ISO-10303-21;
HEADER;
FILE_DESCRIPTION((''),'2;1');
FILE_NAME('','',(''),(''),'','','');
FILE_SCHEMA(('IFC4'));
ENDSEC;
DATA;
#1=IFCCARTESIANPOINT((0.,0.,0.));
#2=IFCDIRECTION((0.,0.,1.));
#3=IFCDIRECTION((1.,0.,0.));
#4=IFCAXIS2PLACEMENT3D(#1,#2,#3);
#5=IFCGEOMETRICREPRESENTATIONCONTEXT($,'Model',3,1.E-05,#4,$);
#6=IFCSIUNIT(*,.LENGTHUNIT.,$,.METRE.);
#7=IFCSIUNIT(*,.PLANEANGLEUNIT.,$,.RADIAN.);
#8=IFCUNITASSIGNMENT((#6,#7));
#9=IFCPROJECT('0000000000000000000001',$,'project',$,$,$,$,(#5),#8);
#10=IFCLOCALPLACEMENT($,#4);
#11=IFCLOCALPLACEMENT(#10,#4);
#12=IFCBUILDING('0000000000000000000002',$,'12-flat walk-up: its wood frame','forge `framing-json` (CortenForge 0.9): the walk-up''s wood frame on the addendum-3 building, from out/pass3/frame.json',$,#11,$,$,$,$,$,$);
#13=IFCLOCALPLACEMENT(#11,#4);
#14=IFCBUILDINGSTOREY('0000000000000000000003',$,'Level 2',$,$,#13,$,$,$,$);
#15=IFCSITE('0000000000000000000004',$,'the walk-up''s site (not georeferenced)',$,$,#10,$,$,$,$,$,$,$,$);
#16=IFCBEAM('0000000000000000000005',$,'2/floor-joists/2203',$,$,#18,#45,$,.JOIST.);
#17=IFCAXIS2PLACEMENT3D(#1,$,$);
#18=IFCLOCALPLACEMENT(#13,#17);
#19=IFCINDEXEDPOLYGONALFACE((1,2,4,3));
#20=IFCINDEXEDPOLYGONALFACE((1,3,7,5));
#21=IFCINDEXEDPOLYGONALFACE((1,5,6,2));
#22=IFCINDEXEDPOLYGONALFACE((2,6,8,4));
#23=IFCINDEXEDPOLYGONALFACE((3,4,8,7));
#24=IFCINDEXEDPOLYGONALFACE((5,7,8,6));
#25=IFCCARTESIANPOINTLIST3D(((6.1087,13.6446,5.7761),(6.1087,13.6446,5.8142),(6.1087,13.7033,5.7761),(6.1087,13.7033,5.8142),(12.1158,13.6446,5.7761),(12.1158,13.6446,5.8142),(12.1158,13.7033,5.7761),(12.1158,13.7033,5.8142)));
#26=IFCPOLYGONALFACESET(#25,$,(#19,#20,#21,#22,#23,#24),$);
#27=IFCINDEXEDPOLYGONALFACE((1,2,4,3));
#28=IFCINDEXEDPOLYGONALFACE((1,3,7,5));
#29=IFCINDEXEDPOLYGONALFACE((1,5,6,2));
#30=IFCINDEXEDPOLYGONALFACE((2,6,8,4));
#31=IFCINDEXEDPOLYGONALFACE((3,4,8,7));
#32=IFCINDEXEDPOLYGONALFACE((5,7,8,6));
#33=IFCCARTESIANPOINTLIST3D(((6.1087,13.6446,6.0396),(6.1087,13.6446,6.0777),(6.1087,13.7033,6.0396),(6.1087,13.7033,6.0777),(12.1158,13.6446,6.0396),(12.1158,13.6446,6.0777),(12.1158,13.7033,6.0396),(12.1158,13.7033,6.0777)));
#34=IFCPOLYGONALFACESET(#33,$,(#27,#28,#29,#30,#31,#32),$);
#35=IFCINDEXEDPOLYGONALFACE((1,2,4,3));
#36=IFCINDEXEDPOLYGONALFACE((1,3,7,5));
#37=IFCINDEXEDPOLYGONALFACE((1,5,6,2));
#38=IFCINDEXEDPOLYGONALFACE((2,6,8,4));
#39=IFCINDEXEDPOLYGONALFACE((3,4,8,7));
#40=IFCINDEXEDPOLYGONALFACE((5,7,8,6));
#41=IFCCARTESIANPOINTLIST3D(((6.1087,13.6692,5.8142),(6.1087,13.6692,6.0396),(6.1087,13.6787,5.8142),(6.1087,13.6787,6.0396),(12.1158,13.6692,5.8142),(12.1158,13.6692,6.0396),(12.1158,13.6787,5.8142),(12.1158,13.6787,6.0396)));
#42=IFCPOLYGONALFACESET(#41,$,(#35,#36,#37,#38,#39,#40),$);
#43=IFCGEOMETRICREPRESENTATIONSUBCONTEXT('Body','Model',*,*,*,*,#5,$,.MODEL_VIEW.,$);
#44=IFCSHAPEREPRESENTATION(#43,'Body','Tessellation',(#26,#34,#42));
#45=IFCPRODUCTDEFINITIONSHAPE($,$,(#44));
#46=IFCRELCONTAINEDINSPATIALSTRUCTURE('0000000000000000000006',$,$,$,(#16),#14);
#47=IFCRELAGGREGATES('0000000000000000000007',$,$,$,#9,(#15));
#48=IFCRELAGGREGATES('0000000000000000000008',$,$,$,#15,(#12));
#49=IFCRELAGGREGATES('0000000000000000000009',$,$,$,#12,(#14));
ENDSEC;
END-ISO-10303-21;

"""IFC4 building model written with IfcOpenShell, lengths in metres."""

from ifc_helpers import new_model, si_unit, frame, frame_2d, origin, origin_with_axes, place, context, subcontext, project, spatial, rectangle, extrude, element, save


model = new_model("IFC4")

# Units and contexts
model_context = context("Model", 3, precision=1e-05, world=origin_with_axes())
body_context = subcontext(model_context, "Body", "Model", "MODEL_VIEW")
ifc_project = project(units=[si_unit("LENGTHUNIT", "METRE"), si_unit("PLANEANGLEUNIT", "RADIAN")], contexts=[model_context])

# Site, building, storey
site_placement = place(None, origin_with_axes())
site = spatial("IfcSite", under=ifc_project, at=site_placement, Name="the walk-up's site (not georeferenced)")
building_placement = place(site_placement, origin_with_axes())
building = spatial("IfcBuilding", under=site, at=building_placement, Name="12-flat walk-up: its wood frame", Description="forge `framing-json` (CortenForge 0.9): the walk-up's wood frame on the addendum-3 building, from out/pass3/frame.json")
storey_placement = place(building_placement, origin_with_axes())
storey = spatial("IfcBuildingStorey", under=building, at=storey_placement, Name="Level 2")

# Beam
beam_1_placement = place(storey_placement, frame((6.1087, 13.6446, 5.7761), z_axis=(0.0, 0.0, 1.0), x_axis=(1.0, 0.0, 0.0)))
element("IfcBeam", 1, at=beam_1_placement, inside=storey, Name="2/floor-joists/2203", PredefinedType="JOIST", context=body_context, shape_type="SweptSolid", body=[
    extrude(rectangle(XDim=6.0071, YDim=0.0587, at=frame_2d((3.0036, 0.0294))), origin(), (0.0, 0.0, 1.0), 0.0381),
    extrude(rectangle(XDim=6.0071, YDim=0.0587, at=frame_2d((3.0036, 0.0294))), frame((0.0, 0.0, 0.2635)), (0.0, 0.0, 1.0), 0.0381),
    extrude(rectangle(XDim=6.0071, YDim=0.0095, at=frame_2d((3.0036, 0.0048))), frame((0.0, 0.0246, 0.0381)), (0.0, 0.0, 1.0), 0.2254),
])

save(model, "model.ifc")
